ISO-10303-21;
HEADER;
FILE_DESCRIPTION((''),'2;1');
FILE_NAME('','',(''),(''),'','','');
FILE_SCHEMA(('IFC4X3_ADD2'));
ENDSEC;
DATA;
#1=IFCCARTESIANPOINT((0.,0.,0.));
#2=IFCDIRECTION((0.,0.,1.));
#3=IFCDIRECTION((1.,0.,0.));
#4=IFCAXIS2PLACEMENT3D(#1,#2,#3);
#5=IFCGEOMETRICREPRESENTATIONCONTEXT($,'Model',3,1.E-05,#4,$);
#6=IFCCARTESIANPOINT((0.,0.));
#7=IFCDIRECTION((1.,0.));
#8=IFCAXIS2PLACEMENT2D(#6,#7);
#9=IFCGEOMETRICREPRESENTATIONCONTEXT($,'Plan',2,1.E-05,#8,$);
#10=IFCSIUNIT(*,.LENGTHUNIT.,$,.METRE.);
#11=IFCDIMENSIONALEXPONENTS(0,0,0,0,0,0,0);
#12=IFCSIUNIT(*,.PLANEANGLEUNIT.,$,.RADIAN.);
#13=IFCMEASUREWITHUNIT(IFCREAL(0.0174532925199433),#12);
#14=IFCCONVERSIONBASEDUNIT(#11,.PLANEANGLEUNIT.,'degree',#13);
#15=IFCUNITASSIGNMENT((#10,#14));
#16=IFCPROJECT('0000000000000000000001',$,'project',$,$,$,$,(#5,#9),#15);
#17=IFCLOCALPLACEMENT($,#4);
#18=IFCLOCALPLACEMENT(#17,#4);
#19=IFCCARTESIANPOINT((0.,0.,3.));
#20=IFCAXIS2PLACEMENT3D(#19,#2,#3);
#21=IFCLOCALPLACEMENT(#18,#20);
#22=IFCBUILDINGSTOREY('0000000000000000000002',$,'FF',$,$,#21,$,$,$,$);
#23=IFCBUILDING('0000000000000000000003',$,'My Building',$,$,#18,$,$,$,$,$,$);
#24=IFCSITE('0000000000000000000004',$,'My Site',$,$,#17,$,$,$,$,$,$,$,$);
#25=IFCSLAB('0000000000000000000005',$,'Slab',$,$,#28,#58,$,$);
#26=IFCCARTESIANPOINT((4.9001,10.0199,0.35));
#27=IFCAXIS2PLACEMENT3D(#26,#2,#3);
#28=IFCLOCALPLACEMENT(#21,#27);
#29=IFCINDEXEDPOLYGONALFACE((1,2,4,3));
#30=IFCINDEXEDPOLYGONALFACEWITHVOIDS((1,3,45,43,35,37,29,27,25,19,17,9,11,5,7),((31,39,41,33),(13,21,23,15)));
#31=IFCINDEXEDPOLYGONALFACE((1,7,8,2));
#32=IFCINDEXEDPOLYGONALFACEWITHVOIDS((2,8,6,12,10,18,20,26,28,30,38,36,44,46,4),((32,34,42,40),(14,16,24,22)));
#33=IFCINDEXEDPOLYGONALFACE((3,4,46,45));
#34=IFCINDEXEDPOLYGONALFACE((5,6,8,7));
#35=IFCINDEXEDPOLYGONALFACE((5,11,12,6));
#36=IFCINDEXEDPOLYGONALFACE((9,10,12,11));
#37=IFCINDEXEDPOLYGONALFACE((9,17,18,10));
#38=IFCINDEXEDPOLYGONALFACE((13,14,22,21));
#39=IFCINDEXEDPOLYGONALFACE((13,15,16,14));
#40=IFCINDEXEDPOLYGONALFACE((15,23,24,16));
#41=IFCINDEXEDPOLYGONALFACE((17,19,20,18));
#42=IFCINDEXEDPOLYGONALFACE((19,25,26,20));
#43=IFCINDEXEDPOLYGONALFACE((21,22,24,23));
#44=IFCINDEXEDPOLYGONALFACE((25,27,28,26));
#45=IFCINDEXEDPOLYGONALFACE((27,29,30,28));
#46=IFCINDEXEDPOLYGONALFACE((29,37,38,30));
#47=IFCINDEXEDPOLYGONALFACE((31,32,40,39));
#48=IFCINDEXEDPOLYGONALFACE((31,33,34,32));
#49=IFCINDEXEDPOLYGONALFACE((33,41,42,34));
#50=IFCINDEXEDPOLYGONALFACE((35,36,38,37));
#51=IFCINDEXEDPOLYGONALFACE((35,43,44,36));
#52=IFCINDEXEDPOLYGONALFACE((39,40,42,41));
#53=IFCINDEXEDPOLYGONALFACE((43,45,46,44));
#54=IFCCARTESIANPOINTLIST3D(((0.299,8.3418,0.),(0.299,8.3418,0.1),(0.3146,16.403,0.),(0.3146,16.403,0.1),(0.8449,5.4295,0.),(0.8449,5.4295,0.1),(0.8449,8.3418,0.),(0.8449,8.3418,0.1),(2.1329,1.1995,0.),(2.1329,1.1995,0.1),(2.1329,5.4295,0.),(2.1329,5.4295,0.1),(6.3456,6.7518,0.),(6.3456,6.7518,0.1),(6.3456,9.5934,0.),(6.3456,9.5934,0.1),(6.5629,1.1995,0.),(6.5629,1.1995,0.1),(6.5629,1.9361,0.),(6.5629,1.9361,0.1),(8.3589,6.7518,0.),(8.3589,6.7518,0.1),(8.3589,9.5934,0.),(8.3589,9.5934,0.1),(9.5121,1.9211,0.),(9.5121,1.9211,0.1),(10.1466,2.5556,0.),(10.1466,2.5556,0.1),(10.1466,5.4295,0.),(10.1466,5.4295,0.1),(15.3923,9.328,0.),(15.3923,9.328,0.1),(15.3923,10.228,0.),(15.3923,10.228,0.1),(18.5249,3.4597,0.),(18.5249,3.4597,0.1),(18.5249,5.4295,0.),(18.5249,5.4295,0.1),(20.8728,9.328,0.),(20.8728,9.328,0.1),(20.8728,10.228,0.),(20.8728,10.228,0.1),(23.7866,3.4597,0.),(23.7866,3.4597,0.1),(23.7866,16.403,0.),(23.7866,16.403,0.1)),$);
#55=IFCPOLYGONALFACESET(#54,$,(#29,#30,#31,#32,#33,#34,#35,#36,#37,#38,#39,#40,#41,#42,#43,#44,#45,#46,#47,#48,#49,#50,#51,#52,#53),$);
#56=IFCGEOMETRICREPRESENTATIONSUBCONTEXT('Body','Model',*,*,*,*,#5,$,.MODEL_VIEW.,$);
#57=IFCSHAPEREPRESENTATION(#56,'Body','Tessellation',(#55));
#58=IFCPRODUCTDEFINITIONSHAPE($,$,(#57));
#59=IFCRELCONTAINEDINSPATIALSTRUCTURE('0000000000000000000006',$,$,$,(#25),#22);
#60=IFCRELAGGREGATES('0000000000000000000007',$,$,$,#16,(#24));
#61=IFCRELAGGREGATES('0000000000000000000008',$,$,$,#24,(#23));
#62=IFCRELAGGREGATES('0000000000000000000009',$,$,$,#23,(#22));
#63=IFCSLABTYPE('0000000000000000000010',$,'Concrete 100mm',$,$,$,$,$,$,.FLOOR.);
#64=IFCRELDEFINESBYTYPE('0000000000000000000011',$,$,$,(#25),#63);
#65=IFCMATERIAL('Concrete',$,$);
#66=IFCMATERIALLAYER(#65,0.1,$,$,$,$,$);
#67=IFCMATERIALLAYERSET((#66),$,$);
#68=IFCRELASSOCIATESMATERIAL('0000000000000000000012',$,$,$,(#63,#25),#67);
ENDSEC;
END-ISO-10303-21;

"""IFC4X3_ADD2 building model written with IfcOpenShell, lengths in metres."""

from ifc_helpers import new_model, entity, si_unit, converted_unit, frame, origin_with_axes, origin_2d_with_axis, place, context, subcontext, project, spatial, line, indexed_curve, outline, extrude, material, layer, layer_set, layer_usage, type_object, element, save


model = new_model("IFC4X3_ADD2")

# Units and contexts
model_context = context("Model", 3, precision=1e-05, world=origin_with_axes())
plan_context = context("Plan", 2, precision=1e-05, world=origin_2d_with_axis())
body_context = subcontext(model_context, "Body", "Model", "MODEL_VIEW")
ifc_project = project(units=[si_unit("LENGTHUNIT", "METRE"), converted_unit("PLANEANGLEUNIT", "degree", entity("IfcReal", 0.0174532925199433), si_unit("PLANEANGLEUNIT", "RADIAN"), dimensions=[0, 0, 0, 0, 0, 0, 0])], contexts=[model_context, plan_context])

# Site, building, storey
site_placement = place(None, origin_with_axes())
site = spatial("IfcSite", under=ifc_project, at=site_placement, Name="My Site")
building_placement = place(site_placement, origin_with_axes())
building = spatial("IfcBuilding", under=site, at=building_placement, Name="My Building")
storey_placement = place(building_placement, frame((0.0, 0.0, 3.0), z_axis=(0.0, 0.0, 1.0), x_axis=(1.0, 0.0, 0.0)))
storey = spatial("IfcBuildingStorey", under=building, at=storey_placement, Name="FF")

# Shared definitions
ifc_material = material(Name="Concrete")

# Slab
ifc_layer = layer(ifc_material, 0.1)
ifc_layer_set = layer_set([ifc_layer])
ifc_layer_usage = layer_usage(ifc_layer_set, "AXIS3", "POSITIVE", 0.0)
slab_type = type_object("IfcSlabType", Name="Concrete 100mm", PredefinedType="FLOOR", material=ifc_layer_set)
slab_placement = place(storey_placement, frame((4.9001, 10.0199, 0.35), z_axis=(0.0, 0.0, 1.0), x_axis=(1.0, 0.0, 0.0)))
element("IfcSlab", 1, at=slab_placement, inside=storey, type_object=slab_type, material=ifc_layer_usage, Name="Slab", context=body_context, shape_type="SweptSolid", body=[
    extrude(outline(indexed_curve([(0.3146, 16.403), (0.299, 8.3418), (0.8449, 8.3418), (0.8449, 5.4295), (2.1329, 5.4295), (2.1329, 1.1995), (6.5629, 1.1995), (6.5629, 1.9361), (9.5121, 1.9211), (10.1466, 2.5556), (10.1466, 5.4295), (18.5249, 5.4295), (18.5249, 3.4597), (23.7866, 3.4597), (23.7866, 16.403), (6.3456, 9.5934), (6.3456, 6.7518), (8.3589, 6.7518), (8.3589, 9.5934), (15.3923, 10.228), (15.3923, 9.328), (20.8728, 9.328), (20.8728, 10.228)], segments=[line(15, 14), line(14, 13), line(13, 12), line(12, 11), line(11, 10), line(10, 9), line(9, 8), line(8, 7), line(7, 6), line(6, 5), line(5, 4), line(4, 3), line(3, 2), line(2, 1), line(1, 15)], self_intersect=False), holes=[indexed_curve([(0.3146, 16.403), (0.299, 8.3418), (0.8449, 8.3418), (0.8449, 5.4295), (2.1329, 5.4295), (2.1329, 1.1995), (6.5629, 1.1995), (6.5629, 1.9361), (9.5121, 1.9211), (10.1466, 2.5556), (10.1466, 5.4295), (18.5249, 5.4295), (18.5249, 3.4597), (23.7866, 3.4597), (23.7866, 16.403), (6.3456, 9.5934), (6.3456, 6.7518), (8.3589, 6.7518), (8.3589, 9.5934), (15.3923, 10.228), (15.3923, 9.328), (20.8728, 9.328), (20.8728, 10.228)], segments=[line(23, 22), line(22, 21), line(21, 20), line(20, 23)], self_intersect=False), indexed_curve([(0.3146, 16.403), (0.299, 8.3418), (0.8449, 8.3418), (0.8449, 5.4295), (2.1329, 5.4295), (2.1329, 1.1995), (6.5629, 1.1995), (6.5629, 1.9361), (9.5121, 1.9211), (10.1466, 2.5556), (10.1466, 5.4295), (18.5249, 5.4295), (18.5249, 3.4597), (23.7866, 3.4597), (23.7866, 16.403), (6.3456, 9.5934), (6.3456, 6.7518), (8.3589, 6.7518), (8.3589, 9.5934), (15.3923, 10.228), (15.3923, 9.328), (20.8728, 9.328), (20.8728, 10.228)], segments=[line(19, 18), line(18, 17), line(17, 16), line(16, 19)], self_intersect=False)]), None, (0.0, 0.0, 1.0), 0.1),
])

save(model, "model.ifc")
